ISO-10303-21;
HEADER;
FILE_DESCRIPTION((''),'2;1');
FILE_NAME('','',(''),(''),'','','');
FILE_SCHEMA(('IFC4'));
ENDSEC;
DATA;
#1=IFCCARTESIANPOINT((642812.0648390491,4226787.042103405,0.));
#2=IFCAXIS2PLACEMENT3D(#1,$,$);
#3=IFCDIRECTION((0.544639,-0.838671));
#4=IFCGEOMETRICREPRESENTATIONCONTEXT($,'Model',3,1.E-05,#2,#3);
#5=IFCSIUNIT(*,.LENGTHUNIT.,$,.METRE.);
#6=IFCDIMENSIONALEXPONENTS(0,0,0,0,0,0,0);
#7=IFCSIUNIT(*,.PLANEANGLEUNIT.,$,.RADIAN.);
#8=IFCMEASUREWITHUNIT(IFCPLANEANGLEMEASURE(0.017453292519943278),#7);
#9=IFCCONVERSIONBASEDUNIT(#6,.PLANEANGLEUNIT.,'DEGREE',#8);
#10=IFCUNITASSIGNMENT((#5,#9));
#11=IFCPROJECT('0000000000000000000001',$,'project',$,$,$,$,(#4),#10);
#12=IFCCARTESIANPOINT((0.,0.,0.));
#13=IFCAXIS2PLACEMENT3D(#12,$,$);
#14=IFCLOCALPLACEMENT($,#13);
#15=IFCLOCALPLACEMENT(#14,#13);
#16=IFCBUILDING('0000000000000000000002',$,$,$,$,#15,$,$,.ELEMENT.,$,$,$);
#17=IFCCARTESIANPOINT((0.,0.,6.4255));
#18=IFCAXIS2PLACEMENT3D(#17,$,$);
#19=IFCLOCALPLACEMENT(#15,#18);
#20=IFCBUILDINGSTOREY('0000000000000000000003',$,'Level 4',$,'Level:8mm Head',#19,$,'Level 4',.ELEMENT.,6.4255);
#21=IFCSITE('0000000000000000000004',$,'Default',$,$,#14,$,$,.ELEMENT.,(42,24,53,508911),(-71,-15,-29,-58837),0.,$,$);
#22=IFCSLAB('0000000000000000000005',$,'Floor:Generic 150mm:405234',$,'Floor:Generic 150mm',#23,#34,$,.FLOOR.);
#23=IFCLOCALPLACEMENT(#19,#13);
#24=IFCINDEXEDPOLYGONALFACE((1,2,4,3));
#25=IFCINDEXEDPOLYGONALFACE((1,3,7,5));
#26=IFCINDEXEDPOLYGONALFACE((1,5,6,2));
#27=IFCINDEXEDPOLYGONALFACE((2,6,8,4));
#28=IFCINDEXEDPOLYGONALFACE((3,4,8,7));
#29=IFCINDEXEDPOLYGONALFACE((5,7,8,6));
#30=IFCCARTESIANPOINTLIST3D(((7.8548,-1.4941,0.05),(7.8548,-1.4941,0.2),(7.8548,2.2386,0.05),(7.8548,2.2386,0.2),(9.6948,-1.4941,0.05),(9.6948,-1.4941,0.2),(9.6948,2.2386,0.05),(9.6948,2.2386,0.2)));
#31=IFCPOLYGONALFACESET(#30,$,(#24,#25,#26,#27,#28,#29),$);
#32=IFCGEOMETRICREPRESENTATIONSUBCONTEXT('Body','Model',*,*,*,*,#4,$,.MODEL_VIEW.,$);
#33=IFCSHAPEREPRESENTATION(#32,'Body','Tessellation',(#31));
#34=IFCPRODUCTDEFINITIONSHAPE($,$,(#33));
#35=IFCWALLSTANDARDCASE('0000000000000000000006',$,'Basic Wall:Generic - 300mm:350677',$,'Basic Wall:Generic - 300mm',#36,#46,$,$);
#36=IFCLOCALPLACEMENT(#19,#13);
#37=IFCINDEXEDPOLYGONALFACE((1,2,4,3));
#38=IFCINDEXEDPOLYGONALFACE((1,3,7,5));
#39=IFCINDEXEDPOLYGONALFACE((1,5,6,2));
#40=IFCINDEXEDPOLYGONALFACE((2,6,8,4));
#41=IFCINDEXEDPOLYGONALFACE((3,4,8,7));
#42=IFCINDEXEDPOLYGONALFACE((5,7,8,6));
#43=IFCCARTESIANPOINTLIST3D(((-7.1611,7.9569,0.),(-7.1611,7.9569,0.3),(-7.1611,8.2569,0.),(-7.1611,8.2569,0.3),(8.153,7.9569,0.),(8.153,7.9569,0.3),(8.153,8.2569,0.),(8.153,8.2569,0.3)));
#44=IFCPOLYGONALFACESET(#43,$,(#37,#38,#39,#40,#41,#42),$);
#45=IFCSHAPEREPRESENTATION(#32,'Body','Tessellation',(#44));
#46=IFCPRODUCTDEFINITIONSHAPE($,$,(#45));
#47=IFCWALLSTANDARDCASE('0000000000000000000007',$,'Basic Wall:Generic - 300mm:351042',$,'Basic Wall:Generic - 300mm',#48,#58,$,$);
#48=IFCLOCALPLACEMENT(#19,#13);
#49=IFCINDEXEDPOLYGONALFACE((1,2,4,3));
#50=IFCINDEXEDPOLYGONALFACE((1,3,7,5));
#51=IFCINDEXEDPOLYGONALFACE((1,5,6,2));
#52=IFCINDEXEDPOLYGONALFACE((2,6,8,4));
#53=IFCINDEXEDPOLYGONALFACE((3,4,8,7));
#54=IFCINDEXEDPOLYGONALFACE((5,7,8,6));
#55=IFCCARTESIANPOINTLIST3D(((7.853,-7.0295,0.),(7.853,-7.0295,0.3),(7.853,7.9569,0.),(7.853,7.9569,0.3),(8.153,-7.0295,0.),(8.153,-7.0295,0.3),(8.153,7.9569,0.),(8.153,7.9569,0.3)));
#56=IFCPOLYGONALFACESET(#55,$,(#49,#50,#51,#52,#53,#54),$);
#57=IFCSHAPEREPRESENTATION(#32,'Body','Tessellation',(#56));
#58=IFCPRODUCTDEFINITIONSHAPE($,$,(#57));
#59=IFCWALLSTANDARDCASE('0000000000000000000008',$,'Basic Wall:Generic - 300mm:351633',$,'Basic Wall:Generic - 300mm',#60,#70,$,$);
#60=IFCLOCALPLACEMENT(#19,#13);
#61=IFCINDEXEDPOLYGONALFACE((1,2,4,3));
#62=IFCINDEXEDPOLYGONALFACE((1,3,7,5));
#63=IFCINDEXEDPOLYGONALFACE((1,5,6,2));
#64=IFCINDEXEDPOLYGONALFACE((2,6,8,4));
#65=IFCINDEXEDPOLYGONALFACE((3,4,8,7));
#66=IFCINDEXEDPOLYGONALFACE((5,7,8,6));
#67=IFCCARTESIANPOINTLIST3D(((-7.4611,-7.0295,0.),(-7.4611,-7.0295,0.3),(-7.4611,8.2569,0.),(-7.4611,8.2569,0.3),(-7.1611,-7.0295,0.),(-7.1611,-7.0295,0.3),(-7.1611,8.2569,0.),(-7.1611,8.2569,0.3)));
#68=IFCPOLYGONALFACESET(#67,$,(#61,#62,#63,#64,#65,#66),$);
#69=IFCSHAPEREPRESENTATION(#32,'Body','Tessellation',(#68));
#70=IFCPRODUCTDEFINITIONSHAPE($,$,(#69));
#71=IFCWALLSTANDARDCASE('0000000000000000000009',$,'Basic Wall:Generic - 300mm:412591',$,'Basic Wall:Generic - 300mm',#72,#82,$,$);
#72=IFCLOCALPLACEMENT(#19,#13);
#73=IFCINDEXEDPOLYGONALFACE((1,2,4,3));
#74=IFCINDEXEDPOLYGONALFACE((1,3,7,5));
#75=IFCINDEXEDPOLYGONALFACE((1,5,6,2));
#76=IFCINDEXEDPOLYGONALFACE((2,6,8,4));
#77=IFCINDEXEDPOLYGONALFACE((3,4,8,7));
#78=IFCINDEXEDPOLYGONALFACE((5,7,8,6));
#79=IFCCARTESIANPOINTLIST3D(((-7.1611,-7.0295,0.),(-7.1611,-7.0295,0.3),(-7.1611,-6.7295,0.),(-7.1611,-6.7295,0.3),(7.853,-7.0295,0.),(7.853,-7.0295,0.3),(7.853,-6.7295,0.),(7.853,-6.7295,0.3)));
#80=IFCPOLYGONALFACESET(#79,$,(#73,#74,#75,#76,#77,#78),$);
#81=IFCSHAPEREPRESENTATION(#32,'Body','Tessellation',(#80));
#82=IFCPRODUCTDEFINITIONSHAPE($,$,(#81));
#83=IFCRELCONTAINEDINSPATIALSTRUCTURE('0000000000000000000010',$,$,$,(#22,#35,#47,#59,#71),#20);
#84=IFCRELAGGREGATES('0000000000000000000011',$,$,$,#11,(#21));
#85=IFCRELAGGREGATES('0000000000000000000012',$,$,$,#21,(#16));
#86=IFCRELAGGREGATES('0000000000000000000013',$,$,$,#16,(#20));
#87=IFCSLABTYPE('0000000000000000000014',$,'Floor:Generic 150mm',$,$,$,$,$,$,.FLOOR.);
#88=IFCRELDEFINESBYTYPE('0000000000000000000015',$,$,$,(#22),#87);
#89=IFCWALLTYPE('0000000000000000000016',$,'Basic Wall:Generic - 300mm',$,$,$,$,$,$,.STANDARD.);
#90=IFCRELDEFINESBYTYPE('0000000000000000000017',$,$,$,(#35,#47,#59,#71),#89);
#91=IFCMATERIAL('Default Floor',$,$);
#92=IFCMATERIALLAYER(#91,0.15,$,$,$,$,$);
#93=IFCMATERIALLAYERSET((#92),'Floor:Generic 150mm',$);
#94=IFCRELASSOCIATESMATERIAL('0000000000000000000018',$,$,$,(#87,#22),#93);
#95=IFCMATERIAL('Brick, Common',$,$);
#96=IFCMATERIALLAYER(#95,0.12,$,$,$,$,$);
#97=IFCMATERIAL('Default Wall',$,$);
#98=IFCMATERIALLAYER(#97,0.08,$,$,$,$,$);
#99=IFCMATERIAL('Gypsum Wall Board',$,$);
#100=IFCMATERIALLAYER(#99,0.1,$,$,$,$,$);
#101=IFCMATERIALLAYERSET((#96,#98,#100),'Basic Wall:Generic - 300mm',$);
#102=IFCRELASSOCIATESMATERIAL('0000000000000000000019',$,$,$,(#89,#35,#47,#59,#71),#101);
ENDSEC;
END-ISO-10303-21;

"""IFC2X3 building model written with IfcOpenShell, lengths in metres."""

from ifc_helpers import new_model, entity, si_unit, converted_unit, direction, frame, frame_2d, origin, place, context, subcontext, project, spatial, rectangle, extrude, clip, halfspace, material, layer, layer_set, layer_usage, type_object, element, save


model = new_model("IFC2X3")

# Units and contexts
model_context = context("Model", 3, precision=1e-05, world=frame((642812.0648390491, 4226787.042103405, 0.0)), true_north=direction((0.544639, -0.838671)))
body_context = subcontext(model_context, "Body", "Model", "MODEL_VIEW")
ifc_project = project(units=[si_unit("LENGTHUNIT", "METRE"), converted_unit("PLANEANGLEUNIT", "DEGREE", entity("IfcPlaneAngleMeasure", 0.017453292519943278), si_unit("PLANEANGLEUNIT", "RADIAN"), dimensions=[0, 0, 0, 0, 0, 0, 0])], contexts=[model_context])

# Site, building, storey
site_placement = place(None, origin())
site = spatial("IfcSite", under=ifc_project, at=site_placement, Name="Default", CompositionType="ELEMENT", RefLatitude=(42, 24, 53, 508911), RefLongitude=(-71, -15, -29, -58837), RefElevation=0.0)
building_placement = place(site_placement, origin())
building = spatial("IfcBuilding", under=site, at=building_placement, CompositionType="ELEMENT")
storey_placement = place(building_placement, frame((0.0, 0.0, 6.4255)))
storey = spatial("IfcBuildingStorey", under=building, at=storey_placement, Name="Level 4", ObjectType="Level:8mm Head", LongName="Level 4", CompositionType="ELEMENT", Elevation=6.4255)

# Slab
ifc_material_1 = material(Name="Default Floor")
ifc_layer_1 = layer(ifc_material_1, 0.15)
ifc_layer_set_1 = layer_set([ifc_layer_1], Name="Floor:Generic 150mm")
ifc_layer_usage_1 = layer_usage(ifc_layer_set_1, "AXIS3", "POSITIVE", 0.0)
slab_type = type_object("IfcSlabType", Name="Floor:Generic 150mm", PredefinedType="FLOOR", material=ifc_layer_set_1)
slab_placement = place(storey_placement, origin())
element("IfcSlab", 1, at=slab_placement, inside=storey, type_object=slab_type, material=ifc_layer_usage_1, Name="Floor:Generic 150mm:405234", ObjectType="Floor:Generic 150mm", PredefinedType="FLOOR", context=body_context, shape_type="SweptSolid", body=[
    extrude(rectangle(XDim=3.7327, YDim=1.84, at=frame_2d((0.0, 0.0), x_axis=(1.0, 0.0))), frame((8.7748, 0.3723, 0.2), z_axis=(0.0, 0.0, -1.0), x_axis=(0.0, 1.0, 0.0)), (0.0, 0.0, 1.0), 0.15),
])

# Walls
ifc_material_2 = material(Name="Brick, Common")
ifc_layer_2 = layer(ifc_material_2, 0.12)
ifc_material_3 = material(Name="Default Wall")
ifc_layer_3 = layer(ifc_material_3, 0.08)
ifc_material_4 = material(Name="Gypsum Wall Board")
ifc_layer_4 = layer(ifc_material_4, 0.1)
ifc_layer_set_2 = layer_set([ifc_layer_2, ifc_layer_3, ifc_layer_4], Name="Basic Wall:Generic - 300mm")
ifc_layer_usage_2 = layer_usage(ifc_layer_set_2, "AXIS2", "POSITIVE", -0.15)
wall_type = type_object("IfcWallType", Name="Basic Wall:Generic - 300mm", PredefinedType="STANDARD", material=ifc_layer_set_2)
wall_1_placement = place(storey_placement, frame((8.153, 8.1069, 0.0), z_axis=(0.0, 0.0, 1.0), x_axis=(-1.0, 0.0, 0.0)))
element("IfcWallStandardCase", 2, at=wall_1_placement, inside=storey, type_object=wall_type, material=ifc_layer_usage_2, Name="Basic Wall:Generic - 300mm:350677", ObjectType="Basic Wall:Generic - 300mm", context=body_context, shape_type="Clipping", body=[
    clip(extrude(rectangle(XDim=15.314, YDim=0.3, at=frame_2d((7.657, 0.0), x_axis=(-1.0, 0.0))), origin(), (0.0, 0.0, 1.0), 0.3), halfspace(frame((0.0, 0.0, -6.4255)), True)),
])
wall_2_placement = place(storey_placement, frame((8.003, -7.0295, 0.0), z_axis=(0.0, 0.0, 1.0), x_axis=(0.0, 1.0, 0.0)))
element("IfcWallStandardCase", 3, at=wall_2_placement, inside=storey, type_object=wall_type, material=ifc_layer_usage_2, Name="Basic Wall:Generic - 300mm:351042", ObjectType="Basic Wall:Generic - 300mm", context=body_context, shape_type="Clipping", body=[
    clip(extrude(rectangle(XDim=14.9864, YDim=0.3, at=frame_2d((7.4932, 0.0), x_axis=(1.0, 0.0))), origin(), (0.0, 0.0, 1.0), 0.3), halfspace(frame((0.0, 0.0, -6.4255)), True)),
])
wall_3_placement = place(storey_placement, frame((-7.3111, 8.2569, 0.0), z_axis=(0.0, 0.0, 1.0), x_axis=(0.0, -1.0, 0.0)))
element("IfcWallStandardCase", 4, at=wall_3_placement, inside=storey, type_object=wall_type, material=ifc_layer_usage_2, Name="Basic Wall:Generic - 300mm:351633", ObjectType="Basic Wall:Generic - 300mm", context=body_context, shape_type="Clipping", body=[
    clip(extrude(rectangle(XDim=15.2864, YDim=0.3, at=frame_2d((7.6432, 0.0), x_axis=(-1.0, 0.0))), origin(), (0.0, 0.0, 1.0), 0.3), halfspace(frame((0.0, 0.0, -6.4255)), True)),
])
wall_4_placement = place(storey_placement, frame((-7.1611, -6.8795, 0.0)))
element("IfcWallStandardCase", 5, at=wall_4_placement, inside=storey, type_object=wall_type, material=ifc_layer_usage_2, Name="Basic Wall:Generic - 300mm:412591", ObjectType="Basic Wall:Generic - 300mm", context=body_context, shape_type="Clipping", body=[
    clip(extrude(rectangle(XDim=15.014, YDim=0.3, at=frame_2d((7.507, 0.0), x_axis=(-1.0, 0.0))), origin(), (0.0, 0.0, 1.0), 0.3), halfspace(frame((0.0, 0.0, -6.4255)), True)),
])

save(model, "model.ifc")
